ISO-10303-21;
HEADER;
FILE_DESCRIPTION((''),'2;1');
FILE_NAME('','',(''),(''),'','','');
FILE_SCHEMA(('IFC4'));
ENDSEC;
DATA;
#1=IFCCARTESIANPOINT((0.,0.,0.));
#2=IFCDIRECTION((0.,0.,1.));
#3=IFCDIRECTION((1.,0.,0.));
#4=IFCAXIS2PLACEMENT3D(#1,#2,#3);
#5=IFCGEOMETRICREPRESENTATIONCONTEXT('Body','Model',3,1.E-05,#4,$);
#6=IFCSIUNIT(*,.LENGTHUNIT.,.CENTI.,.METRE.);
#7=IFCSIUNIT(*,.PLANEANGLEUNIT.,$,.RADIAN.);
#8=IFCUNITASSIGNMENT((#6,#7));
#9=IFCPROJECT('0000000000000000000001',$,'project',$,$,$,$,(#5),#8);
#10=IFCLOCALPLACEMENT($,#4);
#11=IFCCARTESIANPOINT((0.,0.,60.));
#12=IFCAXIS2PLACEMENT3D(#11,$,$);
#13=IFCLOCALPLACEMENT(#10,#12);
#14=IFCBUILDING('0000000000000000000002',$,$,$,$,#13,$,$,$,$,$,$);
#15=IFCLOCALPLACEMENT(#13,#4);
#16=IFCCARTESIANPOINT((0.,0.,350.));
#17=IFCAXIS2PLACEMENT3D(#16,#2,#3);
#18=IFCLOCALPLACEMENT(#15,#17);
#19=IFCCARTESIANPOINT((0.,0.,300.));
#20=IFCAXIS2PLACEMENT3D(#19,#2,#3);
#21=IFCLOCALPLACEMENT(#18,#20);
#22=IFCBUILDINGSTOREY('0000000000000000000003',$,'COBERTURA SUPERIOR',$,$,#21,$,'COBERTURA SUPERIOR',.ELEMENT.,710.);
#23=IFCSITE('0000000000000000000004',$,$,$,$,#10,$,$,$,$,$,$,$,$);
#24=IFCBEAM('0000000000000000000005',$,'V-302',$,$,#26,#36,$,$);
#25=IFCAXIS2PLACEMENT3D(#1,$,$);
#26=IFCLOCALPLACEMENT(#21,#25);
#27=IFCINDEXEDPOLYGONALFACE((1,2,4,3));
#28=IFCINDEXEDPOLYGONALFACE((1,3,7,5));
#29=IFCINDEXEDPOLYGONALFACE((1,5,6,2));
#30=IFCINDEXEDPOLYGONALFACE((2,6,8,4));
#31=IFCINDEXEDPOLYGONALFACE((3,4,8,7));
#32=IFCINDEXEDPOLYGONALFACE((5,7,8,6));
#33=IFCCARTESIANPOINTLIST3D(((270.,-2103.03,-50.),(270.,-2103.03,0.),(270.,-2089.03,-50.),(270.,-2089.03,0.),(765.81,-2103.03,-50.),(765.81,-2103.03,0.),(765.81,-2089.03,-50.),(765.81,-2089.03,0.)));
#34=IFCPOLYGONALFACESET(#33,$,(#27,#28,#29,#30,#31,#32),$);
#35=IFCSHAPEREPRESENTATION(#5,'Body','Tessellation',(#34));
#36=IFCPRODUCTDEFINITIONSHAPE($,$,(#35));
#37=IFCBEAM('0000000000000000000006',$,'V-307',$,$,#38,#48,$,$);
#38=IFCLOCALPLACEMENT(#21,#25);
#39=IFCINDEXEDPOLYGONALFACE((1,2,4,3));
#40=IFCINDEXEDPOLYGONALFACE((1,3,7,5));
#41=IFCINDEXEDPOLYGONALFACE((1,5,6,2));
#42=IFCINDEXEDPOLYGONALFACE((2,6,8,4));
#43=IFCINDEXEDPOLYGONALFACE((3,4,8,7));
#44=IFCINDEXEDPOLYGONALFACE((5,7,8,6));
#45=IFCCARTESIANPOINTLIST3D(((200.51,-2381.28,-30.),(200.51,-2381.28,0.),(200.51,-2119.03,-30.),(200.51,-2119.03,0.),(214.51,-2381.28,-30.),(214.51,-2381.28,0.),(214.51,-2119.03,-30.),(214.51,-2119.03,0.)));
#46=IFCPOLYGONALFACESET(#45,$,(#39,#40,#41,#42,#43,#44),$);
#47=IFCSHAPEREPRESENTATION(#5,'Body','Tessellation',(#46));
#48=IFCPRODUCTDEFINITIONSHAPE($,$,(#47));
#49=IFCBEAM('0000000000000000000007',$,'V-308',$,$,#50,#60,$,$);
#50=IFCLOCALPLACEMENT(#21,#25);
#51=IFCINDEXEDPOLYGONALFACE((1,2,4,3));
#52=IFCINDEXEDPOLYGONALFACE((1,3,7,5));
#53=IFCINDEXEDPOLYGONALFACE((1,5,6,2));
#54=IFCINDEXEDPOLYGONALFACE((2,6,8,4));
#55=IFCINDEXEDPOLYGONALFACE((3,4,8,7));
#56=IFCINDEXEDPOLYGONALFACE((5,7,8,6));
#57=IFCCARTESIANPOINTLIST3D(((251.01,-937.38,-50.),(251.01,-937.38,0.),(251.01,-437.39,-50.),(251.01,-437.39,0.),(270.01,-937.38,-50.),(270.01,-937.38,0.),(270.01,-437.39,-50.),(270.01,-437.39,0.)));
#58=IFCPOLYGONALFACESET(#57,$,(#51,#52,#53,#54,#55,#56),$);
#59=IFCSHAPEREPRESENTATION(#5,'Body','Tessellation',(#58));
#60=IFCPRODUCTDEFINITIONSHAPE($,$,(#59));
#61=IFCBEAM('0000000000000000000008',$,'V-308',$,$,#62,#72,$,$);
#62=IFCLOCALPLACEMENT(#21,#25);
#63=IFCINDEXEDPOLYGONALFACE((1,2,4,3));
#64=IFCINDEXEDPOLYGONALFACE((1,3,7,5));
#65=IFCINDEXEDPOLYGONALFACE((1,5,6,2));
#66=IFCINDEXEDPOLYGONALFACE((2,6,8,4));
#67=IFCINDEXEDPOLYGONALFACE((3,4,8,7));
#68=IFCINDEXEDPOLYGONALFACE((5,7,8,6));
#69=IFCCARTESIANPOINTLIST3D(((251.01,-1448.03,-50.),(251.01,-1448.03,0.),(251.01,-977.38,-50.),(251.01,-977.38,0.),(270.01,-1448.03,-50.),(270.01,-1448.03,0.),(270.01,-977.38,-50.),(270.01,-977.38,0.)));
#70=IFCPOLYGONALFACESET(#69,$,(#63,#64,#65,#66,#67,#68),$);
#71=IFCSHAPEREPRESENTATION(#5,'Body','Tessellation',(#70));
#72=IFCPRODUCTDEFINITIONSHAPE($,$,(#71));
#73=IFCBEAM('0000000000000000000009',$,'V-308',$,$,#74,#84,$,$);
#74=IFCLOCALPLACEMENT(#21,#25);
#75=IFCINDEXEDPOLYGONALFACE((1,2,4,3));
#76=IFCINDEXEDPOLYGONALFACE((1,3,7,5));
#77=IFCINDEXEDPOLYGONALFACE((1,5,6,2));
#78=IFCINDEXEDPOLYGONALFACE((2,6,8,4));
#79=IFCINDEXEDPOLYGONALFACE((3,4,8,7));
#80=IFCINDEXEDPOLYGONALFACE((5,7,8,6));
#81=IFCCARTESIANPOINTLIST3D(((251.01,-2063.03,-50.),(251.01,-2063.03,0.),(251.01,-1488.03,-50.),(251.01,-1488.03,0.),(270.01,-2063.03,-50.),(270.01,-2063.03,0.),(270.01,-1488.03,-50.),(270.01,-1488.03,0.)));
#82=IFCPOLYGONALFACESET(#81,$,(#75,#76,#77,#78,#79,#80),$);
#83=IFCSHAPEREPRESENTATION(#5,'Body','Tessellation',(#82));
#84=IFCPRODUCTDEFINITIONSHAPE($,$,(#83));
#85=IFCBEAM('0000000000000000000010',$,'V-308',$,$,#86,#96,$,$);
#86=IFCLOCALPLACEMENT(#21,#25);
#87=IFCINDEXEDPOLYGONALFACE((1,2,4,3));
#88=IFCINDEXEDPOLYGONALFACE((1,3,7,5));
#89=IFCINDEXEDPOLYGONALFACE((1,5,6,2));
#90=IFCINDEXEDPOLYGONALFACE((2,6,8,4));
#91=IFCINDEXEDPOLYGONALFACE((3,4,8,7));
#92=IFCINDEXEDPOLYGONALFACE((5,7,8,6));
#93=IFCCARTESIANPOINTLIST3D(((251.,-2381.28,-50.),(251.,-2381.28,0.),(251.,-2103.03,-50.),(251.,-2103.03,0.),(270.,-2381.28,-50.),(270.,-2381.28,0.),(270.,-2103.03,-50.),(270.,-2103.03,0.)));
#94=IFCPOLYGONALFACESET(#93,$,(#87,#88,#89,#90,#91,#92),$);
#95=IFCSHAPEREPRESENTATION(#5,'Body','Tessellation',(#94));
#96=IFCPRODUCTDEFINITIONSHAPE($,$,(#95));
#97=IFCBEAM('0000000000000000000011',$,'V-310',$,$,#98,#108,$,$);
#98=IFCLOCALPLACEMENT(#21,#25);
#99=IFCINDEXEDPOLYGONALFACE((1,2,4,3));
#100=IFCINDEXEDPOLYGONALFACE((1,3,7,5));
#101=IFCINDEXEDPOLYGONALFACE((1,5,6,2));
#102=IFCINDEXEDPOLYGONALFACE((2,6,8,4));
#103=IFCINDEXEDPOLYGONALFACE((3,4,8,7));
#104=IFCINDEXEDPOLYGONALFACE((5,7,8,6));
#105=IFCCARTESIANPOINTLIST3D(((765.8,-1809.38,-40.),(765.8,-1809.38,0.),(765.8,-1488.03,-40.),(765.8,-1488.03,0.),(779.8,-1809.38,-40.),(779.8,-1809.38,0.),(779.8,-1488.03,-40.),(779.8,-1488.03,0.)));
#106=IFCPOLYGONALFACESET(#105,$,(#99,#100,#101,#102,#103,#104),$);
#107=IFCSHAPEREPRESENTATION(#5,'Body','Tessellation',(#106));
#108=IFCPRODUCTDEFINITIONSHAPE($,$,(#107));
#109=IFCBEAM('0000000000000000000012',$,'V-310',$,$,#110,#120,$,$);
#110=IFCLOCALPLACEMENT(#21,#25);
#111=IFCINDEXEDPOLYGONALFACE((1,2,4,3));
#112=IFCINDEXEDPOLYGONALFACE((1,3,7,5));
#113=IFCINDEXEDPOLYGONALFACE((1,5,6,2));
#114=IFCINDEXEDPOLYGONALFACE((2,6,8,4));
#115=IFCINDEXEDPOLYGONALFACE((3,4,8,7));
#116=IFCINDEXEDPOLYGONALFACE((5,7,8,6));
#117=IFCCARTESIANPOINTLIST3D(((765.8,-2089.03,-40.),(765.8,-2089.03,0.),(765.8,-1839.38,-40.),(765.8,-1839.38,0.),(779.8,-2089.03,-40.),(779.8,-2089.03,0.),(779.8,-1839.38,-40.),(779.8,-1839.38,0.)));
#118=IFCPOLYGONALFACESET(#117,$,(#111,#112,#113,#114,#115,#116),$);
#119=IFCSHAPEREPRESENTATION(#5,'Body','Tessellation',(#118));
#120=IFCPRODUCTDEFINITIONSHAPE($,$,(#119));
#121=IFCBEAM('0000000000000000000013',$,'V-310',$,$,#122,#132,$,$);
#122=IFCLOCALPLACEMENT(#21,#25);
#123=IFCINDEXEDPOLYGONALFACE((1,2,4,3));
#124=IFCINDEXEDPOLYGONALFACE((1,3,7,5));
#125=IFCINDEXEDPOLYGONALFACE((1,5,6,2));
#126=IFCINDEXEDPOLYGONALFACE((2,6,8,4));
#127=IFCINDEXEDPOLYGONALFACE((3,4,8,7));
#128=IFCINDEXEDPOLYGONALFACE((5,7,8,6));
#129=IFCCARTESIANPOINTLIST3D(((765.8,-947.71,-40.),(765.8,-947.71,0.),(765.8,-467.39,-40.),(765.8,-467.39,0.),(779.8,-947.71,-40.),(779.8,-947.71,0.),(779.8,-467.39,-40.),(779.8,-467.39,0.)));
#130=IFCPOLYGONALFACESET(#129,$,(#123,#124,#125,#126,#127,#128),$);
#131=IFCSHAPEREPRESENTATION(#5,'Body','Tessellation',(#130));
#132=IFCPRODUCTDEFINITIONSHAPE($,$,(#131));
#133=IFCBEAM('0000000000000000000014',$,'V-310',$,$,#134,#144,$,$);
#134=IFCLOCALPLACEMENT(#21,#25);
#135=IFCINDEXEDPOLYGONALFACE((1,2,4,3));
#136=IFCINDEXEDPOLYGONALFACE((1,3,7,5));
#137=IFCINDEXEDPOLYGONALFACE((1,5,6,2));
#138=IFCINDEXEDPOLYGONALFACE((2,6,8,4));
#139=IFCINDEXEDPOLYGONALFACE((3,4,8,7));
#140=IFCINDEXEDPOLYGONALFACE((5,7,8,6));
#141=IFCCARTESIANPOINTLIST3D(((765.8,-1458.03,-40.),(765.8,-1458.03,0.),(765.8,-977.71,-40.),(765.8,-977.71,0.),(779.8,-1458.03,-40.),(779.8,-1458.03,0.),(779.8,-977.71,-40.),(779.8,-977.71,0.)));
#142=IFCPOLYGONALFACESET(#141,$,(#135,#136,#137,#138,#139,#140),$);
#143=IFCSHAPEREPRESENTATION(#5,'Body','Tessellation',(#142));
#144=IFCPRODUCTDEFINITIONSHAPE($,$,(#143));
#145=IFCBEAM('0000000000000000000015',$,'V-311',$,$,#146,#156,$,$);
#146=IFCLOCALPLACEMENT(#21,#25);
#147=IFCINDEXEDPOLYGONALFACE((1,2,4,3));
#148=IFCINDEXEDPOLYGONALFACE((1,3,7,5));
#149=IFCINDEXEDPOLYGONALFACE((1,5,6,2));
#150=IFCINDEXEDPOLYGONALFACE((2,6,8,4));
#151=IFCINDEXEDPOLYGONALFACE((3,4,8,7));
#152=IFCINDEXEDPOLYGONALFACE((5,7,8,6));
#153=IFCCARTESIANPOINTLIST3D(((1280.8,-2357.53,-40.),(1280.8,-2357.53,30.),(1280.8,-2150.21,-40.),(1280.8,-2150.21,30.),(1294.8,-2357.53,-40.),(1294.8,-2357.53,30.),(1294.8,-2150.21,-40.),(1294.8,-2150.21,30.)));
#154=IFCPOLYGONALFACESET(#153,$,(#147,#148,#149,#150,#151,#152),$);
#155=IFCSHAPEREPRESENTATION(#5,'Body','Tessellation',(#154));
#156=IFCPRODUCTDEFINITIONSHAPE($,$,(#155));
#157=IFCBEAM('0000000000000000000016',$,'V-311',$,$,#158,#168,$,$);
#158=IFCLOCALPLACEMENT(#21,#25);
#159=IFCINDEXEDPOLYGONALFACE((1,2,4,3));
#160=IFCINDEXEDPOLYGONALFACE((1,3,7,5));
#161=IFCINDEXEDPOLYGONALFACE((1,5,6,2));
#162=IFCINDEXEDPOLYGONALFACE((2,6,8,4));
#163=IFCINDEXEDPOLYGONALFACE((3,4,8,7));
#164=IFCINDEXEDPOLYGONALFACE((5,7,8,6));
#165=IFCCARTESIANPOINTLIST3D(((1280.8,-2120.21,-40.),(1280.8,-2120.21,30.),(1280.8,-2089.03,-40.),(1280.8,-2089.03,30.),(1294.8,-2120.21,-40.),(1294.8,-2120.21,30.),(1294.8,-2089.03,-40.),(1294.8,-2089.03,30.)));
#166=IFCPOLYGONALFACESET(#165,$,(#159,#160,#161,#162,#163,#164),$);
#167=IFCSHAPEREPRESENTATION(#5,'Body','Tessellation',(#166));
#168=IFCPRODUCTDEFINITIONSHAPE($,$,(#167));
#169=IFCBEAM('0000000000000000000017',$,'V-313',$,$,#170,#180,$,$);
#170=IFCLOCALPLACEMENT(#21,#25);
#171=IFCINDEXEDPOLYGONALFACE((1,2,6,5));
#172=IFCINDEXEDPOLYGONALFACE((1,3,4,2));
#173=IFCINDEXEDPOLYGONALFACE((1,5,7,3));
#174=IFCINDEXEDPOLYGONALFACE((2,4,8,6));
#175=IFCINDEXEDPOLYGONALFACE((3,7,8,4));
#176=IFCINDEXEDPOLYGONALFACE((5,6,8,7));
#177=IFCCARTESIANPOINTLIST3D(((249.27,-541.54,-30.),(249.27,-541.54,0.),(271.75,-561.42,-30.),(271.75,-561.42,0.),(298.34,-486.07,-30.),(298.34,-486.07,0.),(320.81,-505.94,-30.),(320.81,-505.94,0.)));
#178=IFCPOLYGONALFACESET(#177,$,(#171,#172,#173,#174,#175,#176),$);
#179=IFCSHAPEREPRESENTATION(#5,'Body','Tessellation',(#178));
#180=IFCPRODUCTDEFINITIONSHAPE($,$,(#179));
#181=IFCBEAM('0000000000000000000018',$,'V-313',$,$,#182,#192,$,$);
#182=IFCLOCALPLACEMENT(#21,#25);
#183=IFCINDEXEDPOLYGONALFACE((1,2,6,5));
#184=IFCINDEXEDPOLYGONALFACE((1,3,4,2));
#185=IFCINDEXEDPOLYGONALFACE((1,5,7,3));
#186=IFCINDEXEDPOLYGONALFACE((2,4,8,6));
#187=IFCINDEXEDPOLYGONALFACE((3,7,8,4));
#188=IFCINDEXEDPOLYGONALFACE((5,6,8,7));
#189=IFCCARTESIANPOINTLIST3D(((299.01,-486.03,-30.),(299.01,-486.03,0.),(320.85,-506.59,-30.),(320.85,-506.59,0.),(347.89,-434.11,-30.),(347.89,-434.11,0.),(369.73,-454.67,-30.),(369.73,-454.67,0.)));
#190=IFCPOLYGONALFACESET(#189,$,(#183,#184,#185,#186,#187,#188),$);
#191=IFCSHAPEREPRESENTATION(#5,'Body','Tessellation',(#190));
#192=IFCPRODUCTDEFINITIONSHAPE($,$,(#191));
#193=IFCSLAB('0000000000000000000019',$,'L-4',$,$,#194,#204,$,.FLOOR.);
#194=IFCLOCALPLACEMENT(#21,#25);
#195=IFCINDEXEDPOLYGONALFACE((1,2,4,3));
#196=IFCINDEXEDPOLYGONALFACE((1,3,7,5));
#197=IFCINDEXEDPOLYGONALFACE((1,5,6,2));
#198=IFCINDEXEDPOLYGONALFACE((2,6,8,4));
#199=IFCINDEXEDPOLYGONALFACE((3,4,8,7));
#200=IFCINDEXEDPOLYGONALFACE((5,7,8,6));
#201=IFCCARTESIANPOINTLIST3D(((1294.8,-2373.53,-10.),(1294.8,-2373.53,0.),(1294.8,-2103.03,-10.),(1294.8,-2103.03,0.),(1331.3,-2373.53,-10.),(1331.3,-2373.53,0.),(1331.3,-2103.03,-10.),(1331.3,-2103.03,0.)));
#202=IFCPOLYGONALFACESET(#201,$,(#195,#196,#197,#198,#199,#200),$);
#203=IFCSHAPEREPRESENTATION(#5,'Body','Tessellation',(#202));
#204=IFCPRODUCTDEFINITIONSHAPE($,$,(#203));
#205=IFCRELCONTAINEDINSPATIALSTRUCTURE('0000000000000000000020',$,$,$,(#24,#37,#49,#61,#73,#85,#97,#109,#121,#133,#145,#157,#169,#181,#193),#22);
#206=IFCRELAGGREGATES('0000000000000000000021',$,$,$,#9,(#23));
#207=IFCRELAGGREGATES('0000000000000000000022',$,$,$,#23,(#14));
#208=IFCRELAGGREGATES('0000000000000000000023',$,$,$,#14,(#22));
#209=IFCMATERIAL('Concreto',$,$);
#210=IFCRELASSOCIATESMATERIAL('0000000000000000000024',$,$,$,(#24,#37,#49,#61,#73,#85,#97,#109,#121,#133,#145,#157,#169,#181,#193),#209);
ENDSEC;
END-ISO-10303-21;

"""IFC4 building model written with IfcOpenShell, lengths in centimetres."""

from ifc_helpers import new_model, si_unit, frame, origin_with_axes, origin_2d_with_axis, place, context, project, spatial, polyline, rectangle, outline, extrude, material, element, save


model = new_model("IFC4")

# Units and contexts
model_context = context("Model", 3, precision=1e-05, world=origin_with_axes(), identifier="Body")
ifc_project = project(units=[si_unit("LENGTHUNIT", "METRE", prefix="CENTI"), si_unit("PLANEANGLEUNIT", "RADIAN")], contexts=[model_context])

# Site, building, storey
site_placement = place(None, origin_with_axes())
site = spatial("IfcSite", under=ifc_project, at=site_placement)
building_placement = place(site_placement, frame((0.0, 0.0, 60.0)))
building = spatial("IfcBuilding", under=site, at=building_placement)
placement_1 = place(building_placement, origin_with_axes())
placement_2 = place(placement_1, frame((0.0, 0.0, 350.0), z_axis=(0.0, 0.0, 1.0), x_axis=(1.0, 0.0, 0.0)))
storey_placement = place(placement_2, frame((0.0, 0.0, 300.0), z_axis=(0.0, 0.0, 1.0), x_axis=(1.0, 0.0, 0.0)))
storey = spatial("IfcBuildingStorey", under=building, at=storey_placement, Name="COBERTURA SUPERIOR", LongName="COBERTURA SUPERIOR", CompositionType="ELEMENT", Elevation=710.0)

# Shared definitions
ifc_material = material(Name="Concreto")

# Beams
beam_1_placement = place(storey_placement, frame((517.9, -2096.03, 0.0), z_axis=(0.0, 0.0, 1.0), x_axis=(1.0, 0.0, 0.0)))
element("IfcBeam", 1, at=beam_1_placement, inside=storey, material=ifc_material, Name="V-302", context=model_context, shape_type="SolidModel", body=[
    extrude(rectangle(XDim=14.0, YDim=50.0, at=origin_2d_with_axis()), frame((-247.91, 0.0, -25.0), z_axis=(1.0, 0.0, 0.0), x_axis=(0.0, -1.0, 0.0)), (0.0, 0.0, 1.0), 495.81),
])
beam_2_placement = place(storey_placement, frame((207.51, -2250.16, 0.0), z_axis=(0.0, 0.0, 1.0), x_axis=(1.0, 0.0, 0.0)))
element("IfcBeam", 2, at=beam_2_placement, inside=storey, material=ifc_material, Name="V-307", context=model_context, shape_type="SolidModel", body=[
    extrude(rectangle(XDim=14.0, YDim=30.0, at=origin_2d_with_axis()), frame((0.0, -131.12, -15.0), z_axis=(0.0, 1.0, 0.0), x_axis=(1.0, 0.0, 0.0)), (0.0, 0.0, 1.0), 262.25),
])
beam_3_placement = place(storey_placement, frame((260.51, -687.38, 0.0), z_axis=(0.0, 0.0, 1.0), x_axis=(1.0, 0.0, 0.0)))
element("IfcBeam", 3, at=beam_3_placement, inside=storey, material=ifc_material, Name="V-308", context=model_context, shape_type="SolidModel", body=[
    extrude(rectangle(XDim=19.0, YDim=50.0, at=origin_2d_with_axis()), frame((0.0, -250.0, -25.0), z_axis=(0.0, 1.0, 0.0), x_axis=(1.0, 0.0, 0.0)), (0.0, 0.0, 1.0), 499.99),
])
beam_4_placement = place(storey_placement, frame((260.51, -1212.7, 0.0), z_axis=(0.0, 0.0, 1.0), x_axis=(1.0, 0.0, 0.0)))
element("IfcBeam", 4, at=beam_4_placement, inside=storey, material=ifc_material, Name="V-308", context=model_context, shape_type="SolidModel", body=[
    extrude(rectangle(XDim=19.0, YDim=50.0, at=origin_2d_with_axis()), frame((0.0, -235.32, -25.0), z_axis=(0.0, 1.0, 0.0), x_axis=(1.0, 0.0, 0.0)), (0.0, 0.0, 1.0), 470.65),
])
beam_5_placement = place(storey_placement, frame((260.51, -1775.53, 0.0), z_axis=(0.0, 0.0, 1.0), x_axis=(1.0, 0.0, 0.0)))
element("IfcBeam", 5, at=beam_5_placement, inside=storey, material=ifc_material, Name="V-308", context=model_context, shape_type="SolidModel", body=[
    extrude(rectangle(XDim=19.0, YDim=50.0, at=origin_2d_with_axis()), frame((0.0, -287.5, -25.0), z_axis=(0.0, 1.0, 0.0), x_axis=(1.0, 0.0, 0.0)), (0.0, 0.0, 1.0), 575.0),
])
beam_6_placement = place(storey_placement, frame((260.5, -2242.16, 0.0), z_axis=(0.0, 0.0, 1.0), x_axis=(1.0, 0.0, 0.0)))
element("IfcBeam", 6, at=beam_6_placement, inside=storey, material=ifc_material, Name="V-308", context=model_context, shape_type="SolidModel", body=[
    extrude(rectangle(XDim=19.0, YDim=50.0, at=origin_2d_with_axis()), frame((0.0, -139.12, -25.0), z_axis=(0.0, 1.0, 0.0), x_axis=(1.0, 0.0, 0.0)), (0.0, 0.0, 1.0), 278.25),
])
beam_7_placement = place(storey_placement, frame((772.8, -1648.7, 0.0), z_axis=(0.0, 0.0, 1.0), x_axis=(1.0, 0.0, 0.0)))
element("IfcBeam", 7, at=beam_7_placement, inside=storey, material=ifc_material, Name="V-310", context=model_context, shape_type="SolidModel", body=[
    extrude(rectangle(XDim=14.0, YDim=40.0, at=origin_2d_with_axis()), frame((0.0, -160.68, -20.0), z_axis=(0.0, 1.0, 0.0), x_axis=(1.0, 0.0, 0.0)), (0.0, 0.0, 1.0), 321.35),
])
beam_8_placement = place(storey_placement, frame((772.8, -1964.2, 0.0), z_axis=(0.0, 0.0, 1.0), x_axis=(1.0, 0.0, 0.0)))
element("IfcBeam", 8, at=beam_8_placement, inside=storey, material=ifc_material, Name="V-310", context=model_context, shape_type="SolidModel", body=[
    extrude(rectangle(XDim=14.0, YDim=40.0, at=origin_2d_with_axis()), frame((0.0, -124.83, -20.0), z_axis=(0.0, 1.0, 0.0), x_axis=(1.0, 0.0, 0.0)), (0.0, 0.0, 1.0), 249.65),
])
for number, where, z_axis, x_axis, name in (
    (9, (772.8, -707.55, 0.0), (0.0, 0.0, 1.0), (1.0, 0.0, 0.0), "V-310"),
    (10, (772.8, -1217.87, 0.0), (0.0, 0.0, 1.0), (1.0, 0.0, 0.0), "V-310"),
):
    element("IfcBeam", number, at=place(storey_placement, frame(where, z_axis=z_axis, x_axis=x_axis)), inside=storey, material=ifc_material, Name=name, context=model_context, shape_type="SolidModel", body=[
        extrude(rectangle(XDim=14.0, YDim=40.0, at=origin_2d_with_axis()), frame((0.0, -240.16, -20.0), z_axis=(0.0, 1.0, 0.0), x_axis=(1.0, 0.0, 0.0)), (0.0, 0.0, 1.0), 480.32),
    ])
beam_9_placement = place(storey_placement, frame((1287.8, -2253.87, 30.0), z_axis=(0.0, 0.0, 1.0), x_axis=(1.0, 0.0, 0.0)))
element("IfcBeam", 11, at=beam_9_placement, inside=storey, material=ifc_material, Name="V-311", context=model_context, shape_type="SolidModel", body=[
    extrude(rectangle(XDim=14.0, YDim=70.0, at=origin_2d_with_axis()), frame((0.0, -103.66, -35.0), z_axis=(0.0, 1.0, 0.0), x_axis=(1.0, 0.0, 0.0)), (0.0, 0.0, 1.0), 207.32),
])
beam_10_placement = place(storey_placement, frame((1287.8, -2104.62, 30.0), z_axis=(0.0, 0.0, 1.0), x_axis=(1.0, 0.0, 0.0)))
element("IfcBeam", 12, at=beam_10_placement, inside=storey, material=ifc_material, Name="V-311", context=model_context, shape_type="SolidModel", body=[
    extrude(rectangle(XDim=14.0, YDim=70.0, at=origin_2d_with_axis()), frame((0.0, -15.59, -35.0), z_axis=(0.0, 1.0, 0.0), x_axis=(1.0, 0.0, 0.0)), (0.0, 0.0, 1.0), 31.18),
])
beam_11_placement = place(storey_placement, frame((285.04, -523.74, 0.0), z_axis=(0.0, 0.0, 1.0), x_axis=(1.0, 0.0, 0.0)))
element("IfcBeam", 13, at=beam_11_placement, inside=storey, material=ifc_material, Name="V-313", context=model_context, shape_type="SolidModel", body=[
    extrude(rectangle(XDim=30.0, YDim=30.0, at=origin_2d_with_axis()), frame((-24.53, -27.74, -15.0), z_axis=(0.662534, 0.749032, 0.0), x_axis=(0.749032, -0.662534, 0.0)), (0.0, 0.0, 1.0), 74.06),
])
beam_12_placement = place(storey_placement, frame((334.37, -470.35, 0.0), z_axis=(0.0, 0.0, 1.0), x_axis=(1.0, 0.0, 0.0)))
element("IfcBeam", 14, at=beam_12_placement, inside=storey, material=ifc_material, Name="V-313", context=model_context, shape_type="SolidModel", body=[
    extrude(rectangle(XDim=30.0, YDim=30.0, at=origin_2d_with_axis()), frame((-24.44, -25.96, -15.0), z_axis=(0.685475, 0.728096, 0.0), x_axis=(0.728096, -0.685475, 0.0)), (0.0, 0.0, 1.0), 71.31),
])

# Slab
slab_1_placement = place(storey_placement, frame((1313.05, -2238.28, 0.0), z_axis=(0.0, 0.0, 1.0), x_axis=(1.0, 0.0, 0.0)))
element("IfcSlab", 15, at=slab_1_placement, inside=storey, material=ifc_material, Name="L-4", PredefinedType="FLOOR", context=model_context, shape_type="SolidModel", body=[
    extrude(outline(polyline([(18.25, 135.25), (-18.25, 135.25), (-18.25, -135.25), (18.25, -135.25), (18.25, 135.25), (18.25, 135.25)])), frame((0.0, 0.0, -10.0), z_axis=(0.0, 0.0, 1.0), x_axis=(1.0, 0.0, 0.0)), (0.0, 0.0, 1.0), 10.0),
])

save(model, "model.ifc")
